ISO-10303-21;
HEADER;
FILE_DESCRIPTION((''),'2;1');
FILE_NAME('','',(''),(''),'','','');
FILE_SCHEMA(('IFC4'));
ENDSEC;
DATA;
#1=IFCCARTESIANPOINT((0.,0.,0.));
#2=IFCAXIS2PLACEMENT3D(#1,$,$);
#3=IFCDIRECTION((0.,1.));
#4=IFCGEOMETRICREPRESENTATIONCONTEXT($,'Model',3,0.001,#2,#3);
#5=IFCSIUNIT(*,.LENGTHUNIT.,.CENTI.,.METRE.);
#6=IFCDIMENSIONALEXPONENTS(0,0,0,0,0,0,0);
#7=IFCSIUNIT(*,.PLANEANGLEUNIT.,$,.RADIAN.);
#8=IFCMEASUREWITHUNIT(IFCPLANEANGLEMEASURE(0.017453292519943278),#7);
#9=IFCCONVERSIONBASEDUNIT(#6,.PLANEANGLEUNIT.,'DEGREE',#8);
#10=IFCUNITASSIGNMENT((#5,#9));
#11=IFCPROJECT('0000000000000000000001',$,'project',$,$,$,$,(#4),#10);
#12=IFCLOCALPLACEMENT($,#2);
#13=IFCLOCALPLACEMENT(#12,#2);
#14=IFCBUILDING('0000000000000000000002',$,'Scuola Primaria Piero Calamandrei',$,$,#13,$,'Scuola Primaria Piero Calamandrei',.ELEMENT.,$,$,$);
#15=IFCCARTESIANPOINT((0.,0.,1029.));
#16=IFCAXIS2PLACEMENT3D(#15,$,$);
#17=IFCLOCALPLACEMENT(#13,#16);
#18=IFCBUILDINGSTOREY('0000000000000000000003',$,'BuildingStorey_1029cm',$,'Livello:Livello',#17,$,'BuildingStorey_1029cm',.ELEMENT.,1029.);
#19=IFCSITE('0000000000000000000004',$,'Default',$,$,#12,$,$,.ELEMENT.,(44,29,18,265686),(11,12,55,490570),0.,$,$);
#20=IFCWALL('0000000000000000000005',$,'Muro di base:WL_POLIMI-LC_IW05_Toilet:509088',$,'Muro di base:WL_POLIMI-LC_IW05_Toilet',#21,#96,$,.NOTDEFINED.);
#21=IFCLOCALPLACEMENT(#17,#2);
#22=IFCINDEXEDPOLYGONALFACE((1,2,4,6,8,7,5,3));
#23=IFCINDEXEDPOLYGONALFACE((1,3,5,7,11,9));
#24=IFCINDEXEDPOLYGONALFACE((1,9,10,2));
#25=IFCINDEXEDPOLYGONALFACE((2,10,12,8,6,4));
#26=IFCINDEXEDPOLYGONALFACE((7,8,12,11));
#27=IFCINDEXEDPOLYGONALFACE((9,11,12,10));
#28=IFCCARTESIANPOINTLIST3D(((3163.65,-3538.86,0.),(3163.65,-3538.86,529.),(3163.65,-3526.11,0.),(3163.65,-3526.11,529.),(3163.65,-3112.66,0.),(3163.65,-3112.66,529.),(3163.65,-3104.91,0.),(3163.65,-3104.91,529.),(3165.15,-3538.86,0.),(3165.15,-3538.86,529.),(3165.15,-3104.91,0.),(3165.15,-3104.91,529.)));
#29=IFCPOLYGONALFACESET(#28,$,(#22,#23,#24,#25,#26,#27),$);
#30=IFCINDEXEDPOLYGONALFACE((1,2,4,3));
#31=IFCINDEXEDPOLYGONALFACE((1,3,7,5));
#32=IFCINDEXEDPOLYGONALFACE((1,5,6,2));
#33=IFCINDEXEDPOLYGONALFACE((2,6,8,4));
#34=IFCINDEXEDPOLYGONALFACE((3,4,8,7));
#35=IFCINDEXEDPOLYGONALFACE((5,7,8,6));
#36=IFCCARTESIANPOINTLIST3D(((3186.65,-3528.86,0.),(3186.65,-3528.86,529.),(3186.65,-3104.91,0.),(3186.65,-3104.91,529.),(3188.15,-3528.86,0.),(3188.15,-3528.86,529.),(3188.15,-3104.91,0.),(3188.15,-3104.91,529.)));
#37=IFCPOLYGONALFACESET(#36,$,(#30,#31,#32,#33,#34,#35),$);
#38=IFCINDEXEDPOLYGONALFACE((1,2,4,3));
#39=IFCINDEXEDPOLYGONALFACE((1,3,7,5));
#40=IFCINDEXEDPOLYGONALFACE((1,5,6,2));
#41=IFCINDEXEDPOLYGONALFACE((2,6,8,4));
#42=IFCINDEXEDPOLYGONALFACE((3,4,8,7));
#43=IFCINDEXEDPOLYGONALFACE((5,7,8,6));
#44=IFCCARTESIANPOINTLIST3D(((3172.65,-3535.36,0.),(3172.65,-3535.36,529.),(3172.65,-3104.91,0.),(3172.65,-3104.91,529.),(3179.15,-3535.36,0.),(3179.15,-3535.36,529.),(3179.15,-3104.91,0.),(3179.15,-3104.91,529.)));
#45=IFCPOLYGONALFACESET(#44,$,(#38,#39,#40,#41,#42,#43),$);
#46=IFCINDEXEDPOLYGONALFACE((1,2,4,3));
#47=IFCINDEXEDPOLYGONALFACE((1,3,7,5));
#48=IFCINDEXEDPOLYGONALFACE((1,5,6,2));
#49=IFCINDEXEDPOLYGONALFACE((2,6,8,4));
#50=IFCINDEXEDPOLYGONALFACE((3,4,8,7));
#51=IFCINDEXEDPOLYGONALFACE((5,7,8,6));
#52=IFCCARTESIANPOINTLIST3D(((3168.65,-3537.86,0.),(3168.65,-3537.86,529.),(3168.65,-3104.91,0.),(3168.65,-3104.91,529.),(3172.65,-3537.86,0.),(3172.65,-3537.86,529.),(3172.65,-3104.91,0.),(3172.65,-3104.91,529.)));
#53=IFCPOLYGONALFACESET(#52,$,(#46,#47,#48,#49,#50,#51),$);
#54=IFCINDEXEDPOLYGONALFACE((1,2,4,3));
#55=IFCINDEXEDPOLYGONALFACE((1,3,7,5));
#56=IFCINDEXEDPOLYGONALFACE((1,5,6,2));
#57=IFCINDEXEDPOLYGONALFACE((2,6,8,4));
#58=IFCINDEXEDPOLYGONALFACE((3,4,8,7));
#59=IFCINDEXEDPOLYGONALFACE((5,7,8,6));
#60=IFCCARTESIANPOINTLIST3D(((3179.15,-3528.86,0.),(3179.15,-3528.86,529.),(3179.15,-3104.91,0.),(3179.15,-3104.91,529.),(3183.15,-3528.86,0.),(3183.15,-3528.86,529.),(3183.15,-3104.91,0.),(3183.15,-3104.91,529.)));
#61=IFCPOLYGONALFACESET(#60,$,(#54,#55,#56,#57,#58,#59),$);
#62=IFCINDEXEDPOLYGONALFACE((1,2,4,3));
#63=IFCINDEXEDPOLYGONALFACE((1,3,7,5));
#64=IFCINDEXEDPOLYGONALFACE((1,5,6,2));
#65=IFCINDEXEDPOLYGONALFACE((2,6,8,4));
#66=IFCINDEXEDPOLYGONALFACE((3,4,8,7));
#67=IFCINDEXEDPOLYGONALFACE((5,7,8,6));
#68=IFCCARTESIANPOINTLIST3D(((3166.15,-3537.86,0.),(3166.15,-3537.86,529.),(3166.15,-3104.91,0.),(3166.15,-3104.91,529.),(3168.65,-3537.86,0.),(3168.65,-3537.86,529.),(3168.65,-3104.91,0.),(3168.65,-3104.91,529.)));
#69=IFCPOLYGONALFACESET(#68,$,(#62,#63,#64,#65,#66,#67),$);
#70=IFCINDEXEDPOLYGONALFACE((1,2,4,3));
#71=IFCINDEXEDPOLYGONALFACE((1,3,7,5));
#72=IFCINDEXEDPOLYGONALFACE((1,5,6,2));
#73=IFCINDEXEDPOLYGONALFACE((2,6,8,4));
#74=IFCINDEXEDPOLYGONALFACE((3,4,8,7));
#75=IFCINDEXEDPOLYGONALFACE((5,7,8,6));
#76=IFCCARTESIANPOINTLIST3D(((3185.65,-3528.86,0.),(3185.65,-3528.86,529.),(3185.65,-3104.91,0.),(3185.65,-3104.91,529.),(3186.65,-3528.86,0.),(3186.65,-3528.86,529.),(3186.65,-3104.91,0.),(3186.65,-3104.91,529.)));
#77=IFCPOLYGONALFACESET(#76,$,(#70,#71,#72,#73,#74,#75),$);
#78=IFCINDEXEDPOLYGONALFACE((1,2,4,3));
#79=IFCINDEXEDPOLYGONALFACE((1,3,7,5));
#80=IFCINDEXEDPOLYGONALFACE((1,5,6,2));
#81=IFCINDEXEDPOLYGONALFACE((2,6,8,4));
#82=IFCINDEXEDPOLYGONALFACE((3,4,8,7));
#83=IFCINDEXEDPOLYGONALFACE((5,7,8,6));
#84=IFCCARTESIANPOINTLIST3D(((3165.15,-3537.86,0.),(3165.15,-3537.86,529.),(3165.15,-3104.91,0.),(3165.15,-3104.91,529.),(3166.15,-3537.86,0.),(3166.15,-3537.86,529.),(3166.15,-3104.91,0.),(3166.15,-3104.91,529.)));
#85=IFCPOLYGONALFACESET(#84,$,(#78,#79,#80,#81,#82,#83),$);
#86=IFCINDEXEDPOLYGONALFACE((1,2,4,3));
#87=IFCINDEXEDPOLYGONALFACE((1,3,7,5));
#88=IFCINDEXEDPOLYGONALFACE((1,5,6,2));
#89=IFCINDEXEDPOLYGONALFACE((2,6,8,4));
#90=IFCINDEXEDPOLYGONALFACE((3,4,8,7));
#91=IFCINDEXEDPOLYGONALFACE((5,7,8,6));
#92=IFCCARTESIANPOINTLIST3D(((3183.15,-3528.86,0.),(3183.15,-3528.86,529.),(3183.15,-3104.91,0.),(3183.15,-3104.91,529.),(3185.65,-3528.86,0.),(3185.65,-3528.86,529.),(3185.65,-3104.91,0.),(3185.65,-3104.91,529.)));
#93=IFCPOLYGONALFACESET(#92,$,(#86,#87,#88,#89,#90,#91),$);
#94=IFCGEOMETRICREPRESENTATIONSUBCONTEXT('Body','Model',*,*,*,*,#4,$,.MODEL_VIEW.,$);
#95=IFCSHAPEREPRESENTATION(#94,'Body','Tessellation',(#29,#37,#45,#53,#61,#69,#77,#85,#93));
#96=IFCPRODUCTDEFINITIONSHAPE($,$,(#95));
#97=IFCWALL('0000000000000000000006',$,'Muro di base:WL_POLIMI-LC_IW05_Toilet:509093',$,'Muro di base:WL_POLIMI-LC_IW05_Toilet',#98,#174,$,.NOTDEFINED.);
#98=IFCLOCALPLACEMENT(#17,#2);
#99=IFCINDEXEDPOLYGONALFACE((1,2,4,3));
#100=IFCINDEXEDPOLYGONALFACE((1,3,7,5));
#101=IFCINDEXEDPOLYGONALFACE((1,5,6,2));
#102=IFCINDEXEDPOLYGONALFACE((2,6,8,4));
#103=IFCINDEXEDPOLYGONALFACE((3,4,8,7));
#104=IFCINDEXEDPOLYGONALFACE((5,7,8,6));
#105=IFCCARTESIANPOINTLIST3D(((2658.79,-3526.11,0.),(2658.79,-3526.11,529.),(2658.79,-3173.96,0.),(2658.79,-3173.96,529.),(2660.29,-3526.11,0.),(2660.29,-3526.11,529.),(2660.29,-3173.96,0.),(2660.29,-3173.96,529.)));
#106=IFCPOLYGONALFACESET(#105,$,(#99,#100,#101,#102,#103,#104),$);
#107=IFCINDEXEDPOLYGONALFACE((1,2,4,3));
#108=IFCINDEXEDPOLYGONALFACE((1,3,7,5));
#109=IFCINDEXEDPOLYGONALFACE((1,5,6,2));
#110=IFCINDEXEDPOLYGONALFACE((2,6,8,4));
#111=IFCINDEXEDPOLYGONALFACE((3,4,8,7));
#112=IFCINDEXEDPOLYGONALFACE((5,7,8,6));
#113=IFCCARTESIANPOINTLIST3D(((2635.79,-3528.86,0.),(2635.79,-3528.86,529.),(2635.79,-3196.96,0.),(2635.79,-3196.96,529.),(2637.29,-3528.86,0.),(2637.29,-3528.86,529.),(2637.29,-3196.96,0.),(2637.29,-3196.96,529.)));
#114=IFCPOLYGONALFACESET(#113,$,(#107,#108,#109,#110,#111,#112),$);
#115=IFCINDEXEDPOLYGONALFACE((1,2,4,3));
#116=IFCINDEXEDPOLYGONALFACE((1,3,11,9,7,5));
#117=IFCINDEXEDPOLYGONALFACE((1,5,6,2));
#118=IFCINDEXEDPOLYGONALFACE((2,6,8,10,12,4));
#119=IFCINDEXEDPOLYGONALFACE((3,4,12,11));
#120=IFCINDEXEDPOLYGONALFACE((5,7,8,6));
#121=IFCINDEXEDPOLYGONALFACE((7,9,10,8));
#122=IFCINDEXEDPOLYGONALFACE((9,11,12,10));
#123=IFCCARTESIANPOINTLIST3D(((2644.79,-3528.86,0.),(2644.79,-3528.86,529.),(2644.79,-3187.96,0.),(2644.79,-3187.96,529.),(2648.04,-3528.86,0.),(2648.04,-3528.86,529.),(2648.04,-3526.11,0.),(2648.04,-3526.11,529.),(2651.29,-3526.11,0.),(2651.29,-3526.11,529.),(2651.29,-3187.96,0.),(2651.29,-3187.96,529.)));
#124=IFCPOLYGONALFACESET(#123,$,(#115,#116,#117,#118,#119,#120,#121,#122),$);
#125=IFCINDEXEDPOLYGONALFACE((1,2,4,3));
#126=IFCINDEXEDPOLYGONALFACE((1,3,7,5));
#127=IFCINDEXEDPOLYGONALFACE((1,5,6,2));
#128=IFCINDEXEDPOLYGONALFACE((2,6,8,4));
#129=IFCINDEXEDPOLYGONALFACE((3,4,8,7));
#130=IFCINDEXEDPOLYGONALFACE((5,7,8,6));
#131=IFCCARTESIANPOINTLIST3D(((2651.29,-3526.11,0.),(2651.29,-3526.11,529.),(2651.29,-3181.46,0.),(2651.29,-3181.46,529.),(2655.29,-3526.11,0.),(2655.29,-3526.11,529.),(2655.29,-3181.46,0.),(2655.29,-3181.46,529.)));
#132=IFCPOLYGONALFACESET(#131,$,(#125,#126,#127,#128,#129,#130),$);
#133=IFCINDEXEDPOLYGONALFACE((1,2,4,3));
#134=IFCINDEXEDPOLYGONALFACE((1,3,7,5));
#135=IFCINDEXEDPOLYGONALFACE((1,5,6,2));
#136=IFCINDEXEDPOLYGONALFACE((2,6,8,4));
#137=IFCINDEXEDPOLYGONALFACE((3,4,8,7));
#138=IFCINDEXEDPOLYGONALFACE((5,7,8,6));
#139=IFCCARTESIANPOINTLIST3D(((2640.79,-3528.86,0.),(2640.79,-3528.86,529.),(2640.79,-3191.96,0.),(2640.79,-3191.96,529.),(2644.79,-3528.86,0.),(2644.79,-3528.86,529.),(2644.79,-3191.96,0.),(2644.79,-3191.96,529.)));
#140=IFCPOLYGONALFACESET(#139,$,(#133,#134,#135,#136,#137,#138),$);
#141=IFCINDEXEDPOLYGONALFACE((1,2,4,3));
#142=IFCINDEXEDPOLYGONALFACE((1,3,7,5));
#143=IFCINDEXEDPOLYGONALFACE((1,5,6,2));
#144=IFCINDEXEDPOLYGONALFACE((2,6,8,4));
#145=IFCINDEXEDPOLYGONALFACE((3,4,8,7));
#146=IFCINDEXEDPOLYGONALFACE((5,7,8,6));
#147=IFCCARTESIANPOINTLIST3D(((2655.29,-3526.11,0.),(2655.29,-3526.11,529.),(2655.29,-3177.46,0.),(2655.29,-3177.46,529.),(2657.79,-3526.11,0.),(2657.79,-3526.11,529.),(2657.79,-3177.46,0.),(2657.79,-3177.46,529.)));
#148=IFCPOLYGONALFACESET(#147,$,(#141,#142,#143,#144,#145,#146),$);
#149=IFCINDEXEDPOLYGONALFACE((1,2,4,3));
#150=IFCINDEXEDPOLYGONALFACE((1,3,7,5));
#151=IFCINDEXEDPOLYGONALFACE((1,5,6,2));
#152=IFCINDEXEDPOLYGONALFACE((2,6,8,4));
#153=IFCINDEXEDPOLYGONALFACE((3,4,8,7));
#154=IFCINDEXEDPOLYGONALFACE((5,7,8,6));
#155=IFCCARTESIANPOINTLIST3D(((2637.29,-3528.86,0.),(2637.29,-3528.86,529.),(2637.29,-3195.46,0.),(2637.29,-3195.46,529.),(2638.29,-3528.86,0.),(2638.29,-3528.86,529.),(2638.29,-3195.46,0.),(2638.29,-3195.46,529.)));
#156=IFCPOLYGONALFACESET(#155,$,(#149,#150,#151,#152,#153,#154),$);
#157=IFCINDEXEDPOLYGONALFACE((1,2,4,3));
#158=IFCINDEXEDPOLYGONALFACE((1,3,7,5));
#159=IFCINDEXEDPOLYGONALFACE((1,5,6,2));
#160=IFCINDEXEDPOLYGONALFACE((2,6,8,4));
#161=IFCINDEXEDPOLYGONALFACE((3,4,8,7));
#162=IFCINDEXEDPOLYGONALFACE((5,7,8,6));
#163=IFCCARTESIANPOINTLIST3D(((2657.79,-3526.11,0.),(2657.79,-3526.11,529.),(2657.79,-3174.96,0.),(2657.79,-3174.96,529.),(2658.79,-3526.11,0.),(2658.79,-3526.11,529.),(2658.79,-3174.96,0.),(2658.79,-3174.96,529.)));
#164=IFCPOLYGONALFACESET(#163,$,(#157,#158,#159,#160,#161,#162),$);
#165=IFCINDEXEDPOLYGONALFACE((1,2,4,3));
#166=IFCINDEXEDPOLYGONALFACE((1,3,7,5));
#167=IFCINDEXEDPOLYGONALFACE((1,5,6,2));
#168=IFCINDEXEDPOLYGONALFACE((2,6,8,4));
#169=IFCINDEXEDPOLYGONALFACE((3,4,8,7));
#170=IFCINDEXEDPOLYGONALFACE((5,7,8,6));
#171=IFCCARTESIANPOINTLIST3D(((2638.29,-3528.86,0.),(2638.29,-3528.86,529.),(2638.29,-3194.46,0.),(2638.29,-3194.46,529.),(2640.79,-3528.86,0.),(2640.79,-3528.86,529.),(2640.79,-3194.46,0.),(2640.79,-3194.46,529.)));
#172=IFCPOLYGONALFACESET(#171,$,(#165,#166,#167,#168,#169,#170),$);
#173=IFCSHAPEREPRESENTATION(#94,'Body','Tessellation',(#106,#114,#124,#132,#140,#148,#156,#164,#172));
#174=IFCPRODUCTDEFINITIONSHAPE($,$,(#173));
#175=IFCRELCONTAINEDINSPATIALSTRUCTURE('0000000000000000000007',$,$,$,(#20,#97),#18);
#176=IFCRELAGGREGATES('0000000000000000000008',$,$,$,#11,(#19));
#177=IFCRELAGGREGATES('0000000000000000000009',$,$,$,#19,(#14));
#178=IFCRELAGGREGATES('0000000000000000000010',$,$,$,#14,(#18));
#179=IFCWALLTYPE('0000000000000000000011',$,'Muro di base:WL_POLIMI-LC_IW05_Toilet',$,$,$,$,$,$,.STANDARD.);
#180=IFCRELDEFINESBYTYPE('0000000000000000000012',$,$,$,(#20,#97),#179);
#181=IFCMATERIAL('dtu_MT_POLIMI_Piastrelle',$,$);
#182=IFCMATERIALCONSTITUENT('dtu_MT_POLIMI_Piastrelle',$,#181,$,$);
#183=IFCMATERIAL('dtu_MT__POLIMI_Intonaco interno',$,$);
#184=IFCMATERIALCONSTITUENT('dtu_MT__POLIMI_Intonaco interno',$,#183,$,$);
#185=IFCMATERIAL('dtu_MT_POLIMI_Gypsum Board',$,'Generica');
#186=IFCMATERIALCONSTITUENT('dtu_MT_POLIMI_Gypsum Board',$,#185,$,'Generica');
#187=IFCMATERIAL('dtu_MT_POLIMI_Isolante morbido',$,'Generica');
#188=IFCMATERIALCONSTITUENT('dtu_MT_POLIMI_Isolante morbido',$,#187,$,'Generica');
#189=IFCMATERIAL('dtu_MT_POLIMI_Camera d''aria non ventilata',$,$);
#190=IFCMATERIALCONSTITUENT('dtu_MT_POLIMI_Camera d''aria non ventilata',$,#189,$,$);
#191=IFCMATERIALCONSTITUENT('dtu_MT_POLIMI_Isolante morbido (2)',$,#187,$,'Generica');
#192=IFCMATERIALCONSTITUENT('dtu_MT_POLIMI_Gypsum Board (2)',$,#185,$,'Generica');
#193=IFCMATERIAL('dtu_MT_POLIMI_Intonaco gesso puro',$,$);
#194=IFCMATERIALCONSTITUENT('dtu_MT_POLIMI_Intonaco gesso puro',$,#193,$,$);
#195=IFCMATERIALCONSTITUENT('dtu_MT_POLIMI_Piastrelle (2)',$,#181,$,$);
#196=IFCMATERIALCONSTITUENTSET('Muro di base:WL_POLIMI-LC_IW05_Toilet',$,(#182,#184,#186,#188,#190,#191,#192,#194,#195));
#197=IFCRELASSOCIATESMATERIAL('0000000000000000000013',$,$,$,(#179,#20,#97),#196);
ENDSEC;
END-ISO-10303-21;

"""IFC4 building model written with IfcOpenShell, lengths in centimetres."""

from ifc_helpers import new_model, entity, si_unit, converted_unit, direction, frame, origin, place, context, subcontext, project, spatial, indexed_curve, outline, extrude, material, constituent, constituent_set, type_object, element, save


model = new_model("IFC4")

# Units and contexts
model_context = context("Model", 3, precision=0.001, world=origin(), true_north=direction((0.0, 1.0)))
body_context = subcontext(model_context, "Body", "Model", "MODEL_VIEW")
ifc_project = project(units=[si_unit("LENGTHUNIT", "METRE", prefix="CENTI"), converted_unit("PLANEANGLEUNIT", "DEGREE", entity("IfcPlaneAngleMeasure", 0.017453292519943278), si_unit("PLANEANGLEUNIT", "RADIAN"), dimensions=[0, 0, 0, 0, 0, 0, 0])], contexts=[model_context])

# Site, building, storey
site_placement = place(None, origin())
site = spatial("IfcSite", under=ifc_project, at=site_placement, Name="Default", CompositionType="ELEMENT", RefLatitude=(44, 29, 18, 265686), RefLongitude=(11, 12, 55, 490570), RefElevation=0.0)
building_placement = place(site_placement, origin())
building = spatial("IfcBuilding", under=site, at=building_placement, Name="Scuola Primaria Piero Calamandrei", LongName="Scuola Primaria Piero Calamandrei", CompositionType="ELEMENT")
storey_placement = place(building_placement, frame((0.0, 0.0, 1029.0)))
storey = spatial("IfcBuildingStorey", under=building, at=storey_placement, Name="BuildingStorey_1029cm", ObjectType="Livello:Livello", LongName="BuildingStorey_1029cm", CompositionType="ELEMENT", Elevation=1029.0)

# Shared definitions
ifc_material_1 = material(Name="dtu_MT_POLIMI_Isolante morbido", Category="Generica")
ifc_material_2 = material(Name="dtu_MT_POLIMI_Gypsum Board", Category="Generica")
ifc_material_3 = material(Name="dtu_MT__POLIMI_Intonaco interno")

# Shared definitions
ifc_material_4 = material(Name="dtu_MT_POLIMI_Camera d'aria non ventilata")
ifc_material_5 = material(Name="dtu_MT_POLIMI_Intonaco gesso puro")

# Shared definitions
ifc_material_6 = material(Name="dtu_MT_POLIMI_Piastrelle")

# Walls
ifc_constituent_1 = constituent(ifc_material_6, Name="dtu_MT_POLIMI_Piastrelle")
ifc_constituent_2 = constituent(ifc_material_3, Name="dtu_MT__POLIMI_Intonaco interno")
ifc_constituent_3 = constituent(ifc_material_2, Name="dtu_MT_POLIMI_Gypsum Board", Category="Generica")
ifc_constituent_4 = constituent(ifc_material_1, Name="dtu_MT_POLIMI_Isolante morbido", Category="Generica")
ifc_constituent_5 = constituent(ifc_material_4, Name="dtu_MT_POLIMI_Camera d'aria non ventilata")
ifc_constituent_6 = constituent(ifc_material_1, Name="dtu_MT_POLIMI_Isolante morbido (2)", Category="Generica")
ifc_constituent_7 = constituent(ifc_material_2, Name="dtu_MT_POLIMI_Gypsum Board (2)", Category="Generica")
ifc_constituent_8 = constituent(ifc_material_5, Name="dtu_MT_POLIMI_Intonaco gesso puro")
ifc_constituent_9 = constituent(ifc_material_6, Name="dtu_MT_POLIMI_Piastrelle (2)")
ifc_constituent_set_1 = constituent_set(constituents=[ifc_constituent_1, ifc_constituent_2, ifc_constituent_3, ifc_constituent_4, ifc_constituent_5, ifc_constituent_6, ifc_constituent_7, ifc_constituent_8, ifc_constituent_9], Name="Muro di base:WL_POLIMI-LC_IW05_Toilet")
wall_type_1 = type_object("IfcWallType", Name="Muro di base:WL_POLIMI-LC_IW05_Toilet", PredefinedType="STANDARD", material=ifc_constituent_set_1)
wall_1_placement = place(storey_placement, frame((3175.9, -3538.86, 0.0), z_axis=(0.0, 0.0, 1.0), x_axis=(0.0, 1.0, 0.0)))
element("IfcWall", 1, at=wall_1_placement, inside=storey, type_object=wall_type_1, material=ifc_constituent_set_1, Name="Muro di base:WL_POLIMI-LC_IW05_Toilet:509088", ObjectType="Muro di base:WL_POLIMI-LC_IW05_Toilet", PredefinedType="NOTDEFINED", context=body_context, shape_type="SweptSolid", body=[
    extrude(outline(indexed_curve([(-208.39, -0.5), (205.06, -0.5), (217.81, -0.5), (217.81, 1.0), (-216.14, 1.0), (-216.14, -0.5), (-208.39, -0.5)], self_intersect=False)), frame((217.81, 11.75, 0.0), z_axis=(0.0, 0.0, 1.0), x_axis=(-1.0, 0.0, 0.0)), (0.0, 0.0, 1.0), 529.0),
    extrude(outline(indexed_curve([(-211.97, -0.75), (211.97, -0.75), (211.97, 0.75), (-211.97, 0.75), (-211.97, -0.75)], self_intersect=False)), frame((221.97, -11.5, 0.0)), (0.0, 0.0, 1.0), 529.0),
    extrude(outline(indexed_curve([(-215.22, -3.25), (215.22, -3.25), (215.22, 3.25), (-215.22, 3.25), (-215.22, -3.25)], self_intersect=False)), frame((218.72, 0.0, 0.0)), (0.0, 0.0, 1.0), 529.0),
    extrude(outline(indexed_curve([(-216.47, -2.0), (216.47, -2.0), (216.47, 2.0), (-216.47, 2.0), (-216.47, -2.0)], self_intersect=False)), frame((217.47, 5.25, 0.0)), (0.0, 0.0, 1.0), 529.0),
    extrude(outline(indexed_curve([(-211.97, -2.0), (211.97, -2.0), (211.97, 2.0), (-211.97, 2.0), (-211.97, -2.0)], self_intersect=False)), frame((221.97, -5.25, 0.0)), (0.0, 0.0, 1.0), 529.0),
    extrude(outline(indexed_curve([(-216.47, -1.25), (216.47, -1.25), (216.47, 1.25), (-216.47, 1.25), (-216.47, -1.25)], self_intersect=False)), frame((217.47, 8.5, 0.0)), (0.0, 0.0, 1.0), 529.0),
    extrude(outline(indexed_curve([(-211.97, -0.5), (211.97, -0.5), (211.97, 0.5), (-211.97, 0.5), (-211.97, -0.5)], self_intersect=False)), frame((221.97, -10.25, 0.0)), (0.0, 0.0, 1.0), 529.0),
    extrude(outline(indexed_curve([(-216.47, -0.5), (216.47, -0.5), (216.47, 0.5), (-216.47, 0.5), (-216.47, -0.5)], self_intersect=False)), frame((217.47, 10.25, 0.0)), (0.0, 0.0, 1.0), 529.0),
    extrude(outline(indexed_curve([(-211.97, -1.25), (211.97, -1.25), (211.97, 1.25), (-211.97, 1.25), (-211.97, -1.25)], self_intersect=False)), frame((221.97, -8.5, 0.0)), (0.0, 0.0, 1.0), 529.0),
])
wall_2_placement = place(storey_placement, frame((2648.04, -3196.96, 0.0), z_axis=(0.0, 0.0, 1.0), x_axis=(0.0, -1.0, 0.0)))
element("IfcWall", 2, at=wall_2_placement, inside=storey, type_object=wall_type_1, material=ifc_constituent_set_1, Name="Muro di base:WL_POLIMI-LC_IW05_Toilet:509093", ObjectType="Muro di base:WL_POLIMI-LC_IW05_Toilet", PredefinedType="NOTDEFINED", context=body_context, shape_type="SweptSolid", body=[
    extrude(outline(indexed_curve([(-0.75, -176.07), (0.75, -176.07), (0.75, 176.07), (-0.75, 176.07), (-0.75, -176.07)], self_intersect=False)), frame((153.07, 11.5, 0.0), z_axis=(0.0, 0.0, 1.0), x_axis=(0.0, -1.0, 0.0)), (0.0, 0.0, 1.0), 529.0),
    extrude(outline(indexed_curve([(-0.75, -165.95), (0.75, -165.95), (0.75, 165.95), (-0.75, 165.95), (-0.75, -165.95)], self_intersect=False)), frame((165.95, -11.5, 0.0), z_axis=(0.0, 0.0, 1.0), x_axis=(0.0, 1.0, 0.0)), (0.0, 0.0, 1.0), 529.0),
    extrude(outline(indexed_curve([(0.0, -111.8), (3.25, -111.8), (3.25, 226.35), (-3.25, 226.35), (-3.25, -114.55), (0.0, -114.55), (0.0, -111.8)], self_intersect=False)), frame((217.35, 0.0, 0.0), z_axis=(0.0, 0.0, 1.0), x_axis=(0.0, 1.0, 0.0)), (0.0, 0.0, 1.0), 529.0),
    extrude(outline(indexed_curve([(-172.32, -2.0), (172.32, -2.0), (172.32, 2.0), (-172.32, 2.0), (-172.32, -2.0)], self_intersect=False)), frame((156.82, 5.25, 0.0)), (0.0, 0.0, 1.0), 529.0),
    extrude(outline(indexed_curve([(-168.45, -2.0), (168.45, -2.0), (168.45, 2.0), (-168.45, 2.0), (-168.45, -2.0)], self_intersect=False)), frame((163.45, -5.25, 0.0)), (0.0, 0.0, 1.0), 529.0),
    extrude(outline(indexed_curve([(-174.32, -1.25), (174.32, -1.25), (174.32, 1.25), (-174.32, 1.25), (-174.32, -1.25)], self_intersect=False)), frame((154.82, 8.5, 0.0)), (0.0, 0.0, 1.0), 529.0),
    extrude(outline(indexed_curve([(-166.7, -0.5), (166.7, -0.5), (166.7, 0.5), (-166.7, 0.5), (-166.7, -0.5)], self_intersect=False)), frame((165.2, -10.25, 0.0)), (0.0, 0.0, 1.0), 529.0),
    extrude(outline(indexed_curve([(-175.57, -0.5), (175.57, -0.5), (175.57, 0.5), (-175.57, 0.5), (-175.57, -0.5)], self_intersect=False)), frame((153.57, 10.25, 0.0)), (0.0, 0.0, 1.0), 529.0),
    extrude(outline(indexed_curve([(-167.2, -1.25), (167.2, -1.25), (167.2, 1.25), (-167.2, 1.25), (-167.2, -1.25)], self_intersect=False)), frame((164.7, -8.5, 0.0)), (0.0, 0.0, 1.0), 529.0),
])

save(model, "model.ifc")
